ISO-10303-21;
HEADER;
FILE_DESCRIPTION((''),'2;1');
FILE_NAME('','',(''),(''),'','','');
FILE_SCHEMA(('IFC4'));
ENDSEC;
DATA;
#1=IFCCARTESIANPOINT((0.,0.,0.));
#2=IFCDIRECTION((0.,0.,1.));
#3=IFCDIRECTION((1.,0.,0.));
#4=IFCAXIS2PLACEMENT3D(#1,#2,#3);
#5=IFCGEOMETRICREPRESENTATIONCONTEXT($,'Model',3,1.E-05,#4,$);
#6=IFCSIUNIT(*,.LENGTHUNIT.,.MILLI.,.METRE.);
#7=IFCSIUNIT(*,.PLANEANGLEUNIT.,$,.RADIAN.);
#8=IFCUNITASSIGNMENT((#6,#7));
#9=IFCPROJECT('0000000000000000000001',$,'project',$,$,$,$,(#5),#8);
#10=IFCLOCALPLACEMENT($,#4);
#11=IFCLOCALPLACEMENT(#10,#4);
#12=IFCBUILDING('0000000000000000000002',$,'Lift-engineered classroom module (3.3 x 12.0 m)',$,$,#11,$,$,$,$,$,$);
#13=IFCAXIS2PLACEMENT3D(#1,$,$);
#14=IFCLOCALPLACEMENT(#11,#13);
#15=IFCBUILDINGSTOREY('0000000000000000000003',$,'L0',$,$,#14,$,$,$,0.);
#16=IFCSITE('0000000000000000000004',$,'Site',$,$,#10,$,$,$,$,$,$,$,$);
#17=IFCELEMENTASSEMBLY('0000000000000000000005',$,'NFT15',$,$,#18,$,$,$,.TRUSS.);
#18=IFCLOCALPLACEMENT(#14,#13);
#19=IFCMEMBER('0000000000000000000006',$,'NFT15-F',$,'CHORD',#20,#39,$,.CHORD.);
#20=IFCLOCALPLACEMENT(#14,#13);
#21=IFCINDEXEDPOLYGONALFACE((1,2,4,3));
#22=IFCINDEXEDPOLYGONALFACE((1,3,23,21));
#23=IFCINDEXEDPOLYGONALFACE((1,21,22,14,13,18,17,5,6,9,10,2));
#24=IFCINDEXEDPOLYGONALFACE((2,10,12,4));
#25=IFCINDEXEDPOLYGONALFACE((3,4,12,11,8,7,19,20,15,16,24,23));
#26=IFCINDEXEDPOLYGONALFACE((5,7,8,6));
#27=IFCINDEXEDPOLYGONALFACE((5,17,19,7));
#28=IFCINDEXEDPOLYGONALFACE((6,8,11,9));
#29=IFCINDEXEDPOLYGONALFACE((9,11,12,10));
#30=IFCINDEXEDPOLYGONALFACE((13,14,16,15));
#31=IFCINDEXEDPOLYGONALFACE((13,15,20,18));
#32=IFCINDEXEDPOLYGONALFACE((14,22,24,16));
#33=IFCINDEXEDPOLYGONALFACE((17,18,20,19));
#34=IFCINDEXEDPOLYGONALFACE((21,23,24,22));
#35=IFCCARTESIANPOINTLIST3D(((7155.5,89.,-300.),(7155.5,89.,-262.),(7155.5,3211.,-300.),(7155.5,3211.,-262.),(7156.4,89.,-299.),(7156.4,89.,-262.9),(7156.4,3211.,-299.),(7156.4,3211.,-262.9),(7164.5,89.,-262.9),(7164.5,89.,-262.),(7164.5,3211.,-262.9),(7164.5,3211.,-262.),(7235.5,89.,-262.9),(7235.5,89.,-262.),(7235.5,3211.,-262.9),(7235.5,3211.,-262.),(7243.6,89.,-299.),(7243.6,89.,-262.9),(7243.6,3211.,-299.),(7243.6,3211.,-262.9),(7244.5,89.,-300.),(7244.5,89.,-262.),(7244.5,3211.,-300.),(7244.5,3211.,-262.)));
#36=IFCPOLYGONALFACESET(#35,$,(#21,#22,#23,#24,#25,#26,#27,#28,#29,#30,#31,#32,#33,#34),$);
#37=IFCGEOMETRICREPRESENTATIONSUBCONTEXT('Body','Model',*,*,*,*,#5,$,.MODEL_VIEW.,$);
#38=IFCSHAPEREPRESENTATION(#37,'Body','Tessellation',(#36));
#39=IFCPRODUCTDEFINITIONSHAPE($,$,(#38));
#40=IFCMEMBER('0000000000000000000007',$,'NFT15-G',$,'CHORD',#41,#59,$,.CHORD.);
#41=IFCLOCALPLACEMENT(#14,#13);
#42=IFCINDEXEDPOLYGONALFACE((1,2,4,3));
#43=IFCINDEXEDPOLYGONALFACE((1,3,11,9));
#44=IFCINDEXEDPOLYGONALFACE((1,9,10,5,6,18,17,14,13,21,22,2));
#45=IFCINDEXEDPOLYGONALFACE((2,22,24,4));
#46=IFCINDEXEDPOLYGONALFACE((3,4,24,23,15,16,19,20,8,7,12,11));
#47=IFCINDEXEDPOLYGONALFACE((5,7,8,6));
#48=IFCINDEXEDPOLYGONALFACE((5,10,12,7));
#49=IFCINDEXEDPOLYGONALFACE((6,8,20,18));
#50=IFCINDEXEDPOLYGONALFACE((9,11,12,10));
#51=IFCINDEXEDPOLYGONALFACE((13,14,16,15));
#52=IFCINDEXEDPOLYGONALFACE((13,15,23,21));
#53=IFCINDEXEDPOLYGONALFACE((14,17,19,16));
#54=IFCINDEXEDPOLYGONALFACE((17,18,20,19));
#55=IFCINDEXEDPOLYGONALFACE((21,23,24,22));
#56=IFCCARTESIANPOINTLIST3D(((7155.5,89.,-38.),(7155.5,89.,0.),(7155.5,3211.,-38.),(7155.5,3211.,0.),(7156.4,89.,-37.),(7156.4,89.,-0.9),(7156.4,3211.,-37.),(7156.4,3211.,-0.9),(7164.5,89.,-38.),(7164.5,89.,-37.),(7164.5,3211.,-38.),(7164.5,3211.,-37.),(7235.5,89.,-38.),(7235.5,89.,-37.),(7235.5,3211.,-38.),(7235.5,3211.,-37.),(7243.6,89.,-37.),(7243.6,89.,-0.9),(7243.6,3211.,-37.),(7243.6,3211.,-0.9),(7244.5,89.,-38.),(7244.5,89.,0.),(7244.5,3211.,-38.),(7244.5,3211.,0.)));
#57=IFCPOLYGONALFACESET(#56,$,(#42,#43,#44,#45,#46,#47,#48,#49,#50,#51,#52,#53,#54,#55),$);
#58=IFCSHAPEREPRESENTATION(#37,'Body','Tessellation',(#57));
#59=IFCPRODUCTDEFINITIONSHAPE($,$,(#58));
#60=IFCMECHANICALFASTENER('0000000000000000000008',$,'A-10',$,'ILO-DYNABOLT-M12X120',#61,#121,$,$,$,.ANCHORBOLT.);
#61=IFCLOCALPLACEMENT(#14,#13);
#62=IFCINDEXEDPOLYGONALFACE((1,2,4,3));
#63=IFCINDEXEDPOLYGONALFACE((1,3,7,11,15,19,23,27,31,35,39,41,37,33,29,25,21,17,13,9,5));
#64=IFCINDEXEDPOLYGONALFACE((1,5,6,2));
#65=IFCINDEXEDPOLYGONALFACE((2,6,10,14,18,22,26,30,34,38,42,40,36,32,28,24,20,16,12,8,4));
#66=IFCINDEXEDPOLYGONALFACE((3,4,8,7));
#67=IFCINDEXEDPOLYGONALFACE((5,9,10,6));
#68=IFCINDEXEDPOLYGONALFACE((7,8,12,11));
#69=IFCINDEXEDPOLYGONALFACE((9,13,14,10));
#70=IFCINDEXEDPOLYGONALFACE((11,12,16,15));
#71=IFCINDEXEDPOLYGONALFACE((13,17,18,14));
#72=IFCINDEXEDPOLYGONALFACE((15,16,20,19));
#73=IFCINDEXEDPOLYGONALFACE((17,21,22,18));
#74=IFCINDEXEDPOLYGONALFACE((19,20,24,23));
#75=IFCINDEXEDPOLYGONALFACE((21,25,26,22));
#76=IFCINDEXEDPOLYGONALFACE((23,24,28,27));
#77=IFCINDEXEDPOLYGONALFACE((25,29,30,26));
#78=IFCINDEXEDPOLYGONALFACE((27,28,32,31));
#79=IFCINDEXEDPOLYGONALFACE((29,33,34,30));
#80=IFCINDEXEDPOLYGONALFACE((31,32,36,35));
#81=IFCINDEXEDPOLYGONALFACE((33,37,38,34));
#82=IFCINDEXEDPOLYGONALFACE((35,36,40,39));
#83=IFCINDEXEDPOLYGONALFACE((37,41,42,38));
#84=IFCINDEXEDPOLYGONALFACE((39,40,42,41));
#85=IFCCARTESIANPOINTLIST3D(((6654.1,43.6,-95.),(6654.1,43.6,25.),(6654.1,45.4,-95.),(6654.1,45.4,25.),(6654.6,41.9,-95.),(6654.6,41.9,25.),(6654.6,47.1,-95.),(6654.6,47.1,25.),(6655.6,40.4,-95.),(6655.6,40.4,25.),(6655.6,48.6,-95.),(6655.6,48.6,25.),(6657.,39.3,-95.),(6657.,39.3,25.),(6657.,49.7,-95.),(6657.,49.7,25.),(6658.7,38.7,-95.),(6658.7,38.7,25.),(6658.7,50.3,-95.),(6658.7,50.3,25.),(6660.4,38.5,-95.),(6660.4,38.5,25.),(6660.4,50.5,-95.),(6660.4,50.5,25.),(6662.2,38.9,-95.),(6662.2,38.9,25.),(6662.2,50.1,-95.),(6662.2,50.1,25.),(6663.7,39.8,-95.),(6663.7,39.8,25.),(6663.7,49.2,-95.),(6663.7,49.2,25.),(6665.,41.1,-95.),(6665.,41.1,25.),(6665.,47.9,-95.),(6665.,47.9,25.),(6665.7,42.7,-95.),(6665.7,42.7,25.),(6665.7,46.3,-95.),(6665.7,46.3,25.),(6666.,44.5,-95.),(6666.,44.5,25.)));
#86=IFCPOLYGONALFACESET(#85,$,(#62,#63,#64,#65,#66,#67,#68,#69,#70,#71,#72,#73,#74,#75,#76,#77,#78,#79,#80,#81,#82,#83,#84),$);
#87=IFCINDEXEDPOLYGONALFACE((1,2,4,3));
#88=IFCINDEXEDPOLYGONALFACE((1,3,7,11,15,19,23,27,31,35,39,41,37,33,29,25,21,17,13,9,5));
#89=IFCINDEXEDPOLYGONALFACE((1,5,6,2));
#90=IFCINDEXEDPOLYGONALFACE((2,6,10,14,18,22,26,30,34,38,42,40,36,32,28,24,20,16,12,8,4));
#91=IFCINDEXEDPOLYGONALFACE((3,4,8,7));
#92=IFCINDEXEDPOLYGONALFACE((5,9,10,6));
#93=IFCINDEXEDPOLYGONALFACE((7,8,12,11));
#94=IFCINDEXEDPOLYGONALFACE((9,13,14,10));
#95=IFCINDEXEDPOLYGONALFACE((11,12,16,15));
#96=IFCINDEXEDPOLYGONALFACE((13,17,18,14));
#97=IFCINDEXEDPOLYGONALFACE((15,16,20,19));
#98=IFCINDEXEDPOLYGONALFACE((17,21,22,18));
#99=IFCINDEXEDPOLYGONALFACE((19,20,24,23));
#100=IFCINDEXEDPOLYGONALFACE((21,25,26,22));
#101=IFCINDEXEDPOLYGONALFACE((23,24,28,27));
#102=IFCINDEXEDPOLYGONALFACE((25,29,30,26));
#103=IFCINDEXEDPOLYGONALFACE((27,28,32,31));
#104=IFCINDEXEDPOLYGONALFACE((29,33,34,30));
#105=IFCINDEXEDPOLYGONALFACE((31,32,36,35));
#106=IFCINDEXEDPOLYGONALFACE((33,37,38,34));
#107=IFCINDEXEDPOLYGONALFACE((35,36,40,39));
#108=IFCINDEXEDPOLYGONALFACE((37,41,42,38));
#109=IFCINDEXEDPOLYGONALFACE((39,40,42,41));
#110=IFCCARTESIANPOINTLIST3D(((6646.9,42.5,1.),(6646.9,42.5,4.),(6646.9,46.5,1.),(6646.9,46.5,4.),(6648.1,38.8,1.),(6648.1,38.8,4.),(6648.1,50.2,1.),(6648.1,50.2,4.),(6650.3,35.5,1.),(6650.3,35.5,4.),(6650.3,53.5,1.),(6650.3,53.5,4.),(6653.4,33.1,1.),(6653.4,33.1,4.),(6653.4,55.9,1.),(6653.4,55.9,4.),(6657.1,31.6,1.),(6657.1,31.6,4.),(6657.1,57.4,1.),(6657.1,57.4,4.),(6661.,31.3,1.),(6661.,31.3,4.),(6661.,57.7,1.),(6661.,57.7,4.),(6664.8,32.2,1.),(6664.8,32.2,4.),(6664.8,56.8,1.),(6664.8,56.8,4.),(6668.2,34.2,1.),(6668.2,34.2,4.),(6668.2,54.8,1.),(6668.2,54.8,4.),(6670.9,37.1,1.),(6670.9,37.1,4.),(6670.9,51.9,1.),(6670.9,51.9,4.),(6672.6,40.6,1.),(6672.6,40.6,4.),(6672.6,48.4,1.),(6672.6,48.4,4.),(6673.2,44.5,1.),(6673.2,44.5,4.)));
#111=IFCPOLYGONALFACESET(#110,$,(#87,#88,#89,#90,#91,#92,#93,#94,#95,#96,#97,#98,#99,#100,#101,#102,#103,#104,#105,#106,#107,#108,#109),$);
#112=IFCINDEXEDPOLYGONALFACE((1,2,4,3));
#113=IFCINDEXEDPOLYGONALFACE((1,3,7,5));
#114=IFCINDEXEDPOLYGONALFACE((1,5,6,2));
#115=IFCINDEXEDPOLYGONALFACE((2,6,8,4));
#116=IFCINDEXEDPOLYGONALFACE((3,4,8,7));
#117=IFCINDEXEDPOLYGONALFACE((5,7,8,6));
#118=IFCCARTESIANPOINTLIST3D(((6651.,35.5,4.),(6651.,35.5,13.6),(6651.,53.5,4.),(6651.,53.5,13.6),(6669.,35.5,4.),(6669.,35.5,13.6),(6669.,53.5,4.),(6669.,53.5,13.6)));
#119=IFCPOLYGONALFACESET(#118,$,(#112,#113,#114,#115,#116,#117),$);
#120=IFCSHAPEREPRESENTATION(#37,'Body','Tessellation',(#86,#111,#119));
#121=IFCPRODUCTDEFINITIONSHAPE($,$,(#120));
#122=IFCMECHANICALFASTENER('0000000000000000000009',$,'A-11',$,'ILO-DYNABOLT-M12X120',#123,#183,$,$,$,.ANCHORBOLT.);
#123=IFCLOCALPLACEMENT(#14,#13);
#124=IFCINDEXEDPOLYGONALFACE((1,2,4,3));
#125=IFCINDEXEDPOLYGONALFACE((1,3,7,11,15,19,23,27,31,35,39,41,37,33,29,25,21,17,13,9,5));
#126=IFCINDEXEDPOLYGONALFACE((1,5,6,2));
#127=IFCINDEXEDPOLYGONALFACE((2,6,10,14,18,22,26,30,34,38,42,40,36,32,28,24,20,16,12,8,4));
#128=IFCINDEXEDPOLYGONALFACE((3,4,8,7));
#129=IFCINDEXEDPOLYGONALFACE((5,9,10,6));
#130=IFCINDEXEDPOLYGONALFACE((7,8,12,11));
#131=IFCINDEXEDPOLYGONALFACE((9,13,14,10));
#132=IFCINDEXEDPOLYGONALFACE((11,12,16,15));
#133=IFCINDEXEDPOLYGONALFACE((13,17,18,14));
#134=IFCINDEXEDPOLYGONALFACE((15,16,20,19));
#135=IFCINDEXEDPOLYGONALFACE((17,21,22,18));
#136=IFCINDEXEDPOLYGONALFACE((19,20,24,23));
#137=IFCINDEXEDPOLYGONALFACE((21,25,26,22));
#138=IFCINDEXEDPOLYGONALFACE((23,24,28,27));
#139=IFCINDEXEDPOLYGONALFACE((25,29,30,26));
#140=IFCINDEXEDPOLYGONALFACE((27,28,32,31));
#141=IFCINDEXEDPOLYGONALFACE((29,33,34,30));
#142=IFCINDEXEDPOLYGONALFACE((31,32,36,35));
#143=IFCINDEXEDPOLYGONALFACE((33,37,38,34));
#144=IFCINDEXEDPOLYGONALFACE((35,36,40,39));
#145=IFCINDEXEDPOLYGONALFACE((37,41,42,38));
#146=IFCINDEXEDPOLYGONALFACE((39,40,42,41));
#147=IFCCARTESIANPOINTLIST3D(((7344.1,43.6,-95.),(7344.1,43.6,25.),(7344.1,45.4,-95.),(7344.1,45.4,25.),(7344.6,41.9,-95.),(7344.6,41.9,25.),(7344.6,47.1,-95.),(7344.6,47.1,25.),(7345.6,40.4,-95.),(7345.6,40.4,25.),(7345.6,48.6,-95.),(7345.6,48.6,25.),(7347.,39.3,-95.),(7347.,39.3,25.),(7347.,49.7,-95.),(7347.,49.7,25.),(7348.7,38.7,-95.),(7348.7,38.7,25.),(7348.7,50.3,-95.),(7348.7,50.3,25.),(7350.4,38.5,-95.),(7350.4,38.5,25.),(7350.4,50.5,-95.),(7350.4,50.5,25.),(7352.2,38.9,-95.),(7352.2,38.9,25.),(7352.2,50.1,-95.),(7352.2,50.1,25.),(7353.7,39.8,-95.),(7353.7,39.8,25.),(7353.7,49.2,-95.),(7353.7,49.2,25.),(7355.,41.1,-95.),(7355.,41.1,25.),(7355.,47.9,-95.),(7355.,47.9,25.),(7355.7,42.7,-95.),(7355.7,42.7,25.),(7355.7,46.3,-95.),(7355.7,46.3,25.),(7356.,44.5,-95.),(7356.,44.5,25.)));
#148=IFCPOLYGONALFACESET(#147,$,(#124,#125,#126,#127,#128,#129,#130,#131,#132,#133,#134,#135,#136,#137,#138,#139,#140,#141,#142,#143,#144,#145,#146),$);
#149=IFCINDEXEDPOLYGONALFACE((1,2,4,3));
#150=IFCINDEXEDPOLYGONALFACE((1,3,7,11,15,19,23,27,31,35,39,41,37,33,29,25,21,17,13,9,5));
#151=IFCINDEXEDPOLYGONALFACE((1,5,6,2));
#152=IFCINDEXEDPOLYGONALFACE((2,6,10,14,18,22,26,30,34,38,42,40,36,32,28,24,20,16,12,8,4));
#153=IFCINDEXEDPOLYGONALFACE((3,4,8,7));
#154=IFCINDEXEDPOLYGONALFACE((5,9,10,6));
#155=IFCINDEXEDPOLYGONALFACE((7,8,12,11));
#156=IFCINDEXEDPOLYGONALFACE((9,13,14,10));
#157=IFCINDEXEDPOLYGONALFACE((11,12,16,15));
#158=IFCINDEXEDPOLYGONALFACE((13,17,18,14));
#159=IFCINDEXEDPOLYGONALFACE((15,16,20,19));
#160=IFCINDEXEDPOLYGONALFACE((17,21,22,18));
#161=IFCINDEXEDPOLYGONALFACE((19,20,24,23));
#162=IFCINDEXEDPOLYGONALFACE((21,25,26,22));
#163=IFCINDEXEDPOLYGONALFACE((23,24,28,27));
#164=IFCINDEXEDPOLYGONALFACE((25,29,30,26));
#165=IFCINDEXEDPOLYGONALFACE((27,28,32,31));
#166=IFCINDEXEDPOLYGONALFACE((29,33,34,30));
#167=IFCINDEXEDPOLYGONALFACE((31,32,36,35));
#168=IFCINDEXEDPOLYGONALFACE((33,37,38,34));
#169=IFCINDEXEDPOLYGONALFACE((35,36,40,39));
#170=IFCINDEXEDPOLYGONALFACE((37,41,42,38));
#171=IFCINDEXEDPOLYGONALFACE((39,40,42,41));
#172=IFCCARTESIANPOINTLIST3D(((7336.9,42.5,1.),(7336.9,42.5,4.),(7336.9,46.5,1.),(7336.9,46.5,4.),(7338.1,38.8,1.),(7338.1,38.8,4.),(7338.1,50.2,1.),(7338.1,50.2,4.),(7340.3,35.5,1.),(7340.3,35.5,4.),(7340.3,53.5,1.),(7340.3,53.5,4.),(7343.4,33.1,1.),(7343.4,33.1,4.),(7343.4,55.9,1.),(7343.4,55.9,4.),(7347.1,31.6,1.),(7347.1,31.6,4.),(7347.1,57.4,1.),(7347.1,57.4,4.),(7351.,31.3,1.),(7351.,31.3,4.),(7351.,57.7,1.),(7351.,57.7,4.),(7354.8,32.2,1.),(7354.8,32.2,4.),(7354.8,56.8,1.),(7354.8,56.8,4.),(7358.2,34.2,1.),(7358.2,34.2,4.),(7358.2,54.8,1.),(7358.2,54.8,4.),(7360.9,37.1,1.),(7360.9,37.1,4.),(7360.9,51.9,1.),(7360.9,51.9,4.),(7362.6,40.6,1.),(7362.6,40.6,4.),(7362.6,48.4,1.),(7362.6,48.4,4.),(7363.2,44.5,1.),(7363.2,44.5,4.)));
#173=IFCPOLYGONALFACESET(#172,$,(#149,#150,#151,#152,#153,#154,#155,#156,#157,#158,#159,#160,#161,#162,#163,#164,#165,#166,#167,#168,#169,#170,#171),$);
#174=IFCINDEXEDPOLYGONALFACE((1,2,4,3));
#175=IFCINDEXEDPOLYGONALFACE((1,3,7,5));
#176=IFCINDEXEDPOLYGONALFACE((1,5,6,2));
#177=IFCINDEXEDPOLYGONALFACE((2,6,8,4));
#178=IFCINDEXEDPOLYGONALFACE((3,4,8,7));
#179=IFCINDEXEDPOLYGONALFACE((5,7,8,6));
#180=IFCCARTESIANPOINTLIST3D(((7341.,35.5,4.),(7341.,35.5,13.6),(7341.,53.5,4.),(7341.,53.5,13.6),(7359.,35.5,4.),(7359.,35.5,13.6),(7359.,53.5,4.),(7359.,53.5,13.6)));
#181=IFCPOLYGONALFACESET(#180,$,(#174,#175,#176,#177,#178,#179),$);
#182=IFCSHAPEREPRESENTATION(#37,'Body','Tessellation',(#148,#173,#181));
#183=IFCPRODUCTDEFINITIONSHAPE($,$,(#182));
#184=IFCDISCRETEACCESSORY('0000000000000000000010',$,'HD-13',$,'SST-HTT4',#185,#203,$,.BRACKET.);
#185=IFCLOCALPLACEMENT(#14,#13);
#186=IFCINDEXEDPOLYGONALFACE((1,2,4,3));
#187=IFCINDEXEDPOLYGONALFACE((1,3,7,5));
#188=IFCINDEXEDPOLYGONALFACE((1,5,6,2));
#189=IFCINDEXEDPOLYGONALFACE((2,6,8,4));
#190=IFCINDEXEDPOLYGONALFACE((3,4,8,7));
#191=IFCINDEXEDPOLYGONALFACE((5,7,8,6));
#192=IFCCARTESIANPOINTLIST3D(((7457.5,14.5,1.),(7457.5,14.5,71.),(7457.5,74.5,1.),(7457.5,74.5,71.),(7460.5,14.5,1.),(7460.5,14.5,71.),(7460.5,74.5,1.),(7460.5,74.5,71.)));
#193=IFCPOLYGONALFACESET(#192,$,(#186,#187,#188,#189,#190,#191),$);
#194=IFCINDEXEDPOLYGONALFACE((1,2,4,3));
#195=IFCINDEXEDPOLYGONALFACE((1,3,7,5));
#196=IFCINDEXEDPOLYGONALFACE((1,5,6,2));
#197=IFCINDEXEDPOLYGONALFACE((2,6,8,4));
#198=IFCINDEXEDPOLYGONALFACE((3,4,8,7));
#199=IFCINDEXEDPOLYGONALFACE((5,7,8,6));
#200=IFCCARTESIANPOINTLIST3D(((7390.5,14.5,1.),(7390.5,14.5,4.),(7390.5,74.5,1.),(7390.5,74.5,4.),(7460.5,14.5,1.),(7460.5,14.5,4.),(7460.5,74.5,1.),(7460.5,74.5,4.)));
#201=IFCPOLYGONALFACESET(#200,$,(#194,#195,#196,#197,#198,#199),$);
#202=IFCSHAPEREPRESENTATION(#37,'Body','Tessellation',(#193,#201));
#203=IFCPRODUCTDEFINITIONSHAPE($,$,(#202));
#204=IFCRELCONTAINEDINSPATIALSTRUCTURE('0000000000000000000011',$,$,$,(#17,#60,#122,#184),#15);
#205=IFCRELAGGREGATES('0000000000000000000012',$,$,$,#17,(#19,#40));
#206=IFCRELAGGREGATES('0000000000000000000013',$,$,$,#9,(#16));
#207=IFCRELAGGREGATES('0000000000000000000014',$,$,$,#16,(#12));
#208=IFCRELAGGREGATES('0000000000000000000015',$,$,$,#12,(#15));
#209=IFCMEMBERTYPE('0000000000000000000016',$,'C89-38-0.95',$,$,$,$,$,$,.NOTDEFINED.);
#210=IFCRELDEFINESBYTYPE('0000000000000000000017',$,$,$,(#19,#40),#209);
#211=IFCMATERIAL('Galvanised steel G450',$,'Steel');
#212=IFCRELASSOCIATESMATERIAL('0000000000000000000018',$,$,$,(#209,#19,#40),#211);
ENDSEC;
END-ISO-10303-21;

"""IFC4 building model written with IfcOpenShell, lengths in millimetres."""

from ifc_helpers import new_model, si_unit, frame, frame_2d, origin, origin_with_axes, origin_2d, place, context, subcontext, project, spatial, rectangle, circle, c_section, extrude, material, material_profile, profile_set, profile_usage, type_object, element, aggregate, save


model = new_model("IFC4")

# Units and contexts
model_context = context("Model", 3, precision=1e-05, world=origin_with_axes())
body_context = subcontext(model_context, "Body", "Model", "MODEL_VIEW")
ifc_project = project(units=[si_unit("LENGTHUNIT", "METRE", prefix="MILLI"), si_unit("PLANEANGLEUNIT", "RADIAN")], contexts=[model_context])

# Site, building, storey
site_placement = place(None, origin_with_axes())
site = spatial("IfcSite", under=ifc_project, at=site_placement, Name="Site")
building_placement = place(site_placement, origin_with_axes())
building = spatial("IfcBuilding", under=site, at=building_placement, Name="Lift-engineered classroom module (3.3 x 12.0 m)")
storey_placement = place(building_placement, origin())
storey = spatial("IfcBuildingStorey", under=building, at=storey_placement, Name="L0", Elevation=0.0)

# Shared definitions
ifc_material = material(Name="Galvanised steel G450", Category="Steel")
ifc_material_profile = material_profile(ifc_material, c_section(Depth=89.0, Width=38.0, WallThickness=0.9, Girth=9.0, at=origin_2d()), Name="C89-38-0.95")
ifc_profile_set = profile_set([ifc_material_profile], Name="C89-38-0.95")
ifc_profile_usage = profile_usage(ifc_profile_set)
member_type = type_object("IfcMemberType", Name="C89-38-0.95", PredefinedType="NOTDEFINED", material=ifc_profile_set)

# Element assembly, members
assembly_1_placement = place(storey_placement, frame((7200.0, 89.0, -300.0)))
assembly_1 = element("IfcElementAssembly", 1, at=assembly_1_placement, inside=storey, Name="NFT15", PredefinedType="TRUSS")
member_1_placement = place(assembly_1_placement, frame((0.0, 0.0, 19.0), z_axis=(0.0, 1.0, 0.0), x_axis=(0.0, 0.0, 1.0)))
member_1 = element("IfcMember", 2, at=member_1_placement, type_object=member_type, material=ifc_profile_usage, Name="NFT15-F", ObjectType="CHORD", PredefinedType="CHORD", context=body_context, shape_type="SweptSolid", body=[
    extrude(c_section(Depth=89.0, Width=38.0, WallThickness=0.9, Girth=9.0, at=origin_2d()), origin(), (0.0, 0.0, 1.0), 3122.0),
])
member_2_placement = place(assembly_1_placement, frame((0.0, 0.0, 281.0), z_axis=(0.0, 1.0, 0.0), x_axis=(0.0, 0.0, -1.0)))
member_2 = element("IfcMember", 3, at=member_2_placement, type_object=member_type, material=ifc_profile_usage, Name="NFT15-G", ObjectType="CHORD", PredefinedType="CHORD", context=body_context, shape_type="SweptSolid", body=[
    extrude(c_section(Depth=89.0, Width=38.0, WallThickness=0.9, Girth=9.0, at=origin_2d()), origin(), (0.0, 0.0, 1.0), 3122.0),
])
aggregate(assembly_1, [member_1, member_2])

# Mechanical fasteners
for number, where, z_axis, x_axis, name in (
    (4, (6660.0, 44.5, 0.0), (0.0, 0.0, 1.0), (1.0, 0.0, 0.0), "A-10"),
    (5, (7350.0, 44.5, 0.0), (0.0, 0.0, 1.0), (1.0, 0.0, 0.0), "A-11"),
):
    element("IfcMechanicalFastener", number, at=place(None, frame(where, z_axis=z_axis, x_axis=x_axis)), inside=storey, Name=name, ObjectType="ILO-DYNABOLT-M12X120", PredefinedType="ANCHORBOLT", context=body_context, shape_type="SweptSolid", body=[
        extrude(circle(Radius=6.0, at=origin_2d()), frame((0.0, 0.0, -95.0), z_axis=(0.0, 0.0, 1.0), x_axis=(1.0, 0.0, 0.0)), (0.0, 0.0, 1.0), 120.0),
        extrude(circle(Radius=13.2, at=origin_2d()), frame((0.0, 0.0, 1.0), z_axis=(0.0, 0.0, 1.0), x_axis=(1.0, 0.0, 0.0)), (0.0, 0.0, 1.0), 3.0),
        extrude(rectangle(XDim=18.0, YDim=18.0, at=origin_2d()), frame((0.0, 0.0, 4.0), z_axis=(0.0, 0.0, 1.0), x_axis=(1.0, 0.0, 0.0)), (0.0, 0.0, 1.0), 9.6),
    ])

# Discrete accessory
for number, where, z_axis, x_axis, name in (
    (6, (7460.5, 44.5, 0.0), (0.0, 0.0, 1.0), (-1.0, 0.0, 0.0), "HD-13"),
):
    element("IfcDiscreteAccessory", number, at=place(None, frame(where, z_axis=z_axis, x_axis=x_axis)), inside=storey, Name=name, ObjectType="SST-HTT4", PredefinedType="BRACKET", context=body_context, shape_type="SweptSolid", body=[
        extrude(rectangle(XDim=3.0, YDim=60.0, at=frame_2d((1.5, 0.0))), frame((0.0, 0.0, 1.0), z_axis=(0.0, 0.0, 1.0), x_axis=(1.0, 0.0, 0.0)), (0.0, 0.0, 1.0), 70.0),
        extrude(rectangle(XDim=70.0, YDim=60.0, at=frame_2d((35.0, 0.0))), frame((0.0, 0.0, 1.0), z_axis=(0.0, 0.0, 1.0), x_axis=(1.0, 0.0, 0.0)), (0.0, 0.0, 1.0), 3.0),
    ])

save(model, "model.ifc")
